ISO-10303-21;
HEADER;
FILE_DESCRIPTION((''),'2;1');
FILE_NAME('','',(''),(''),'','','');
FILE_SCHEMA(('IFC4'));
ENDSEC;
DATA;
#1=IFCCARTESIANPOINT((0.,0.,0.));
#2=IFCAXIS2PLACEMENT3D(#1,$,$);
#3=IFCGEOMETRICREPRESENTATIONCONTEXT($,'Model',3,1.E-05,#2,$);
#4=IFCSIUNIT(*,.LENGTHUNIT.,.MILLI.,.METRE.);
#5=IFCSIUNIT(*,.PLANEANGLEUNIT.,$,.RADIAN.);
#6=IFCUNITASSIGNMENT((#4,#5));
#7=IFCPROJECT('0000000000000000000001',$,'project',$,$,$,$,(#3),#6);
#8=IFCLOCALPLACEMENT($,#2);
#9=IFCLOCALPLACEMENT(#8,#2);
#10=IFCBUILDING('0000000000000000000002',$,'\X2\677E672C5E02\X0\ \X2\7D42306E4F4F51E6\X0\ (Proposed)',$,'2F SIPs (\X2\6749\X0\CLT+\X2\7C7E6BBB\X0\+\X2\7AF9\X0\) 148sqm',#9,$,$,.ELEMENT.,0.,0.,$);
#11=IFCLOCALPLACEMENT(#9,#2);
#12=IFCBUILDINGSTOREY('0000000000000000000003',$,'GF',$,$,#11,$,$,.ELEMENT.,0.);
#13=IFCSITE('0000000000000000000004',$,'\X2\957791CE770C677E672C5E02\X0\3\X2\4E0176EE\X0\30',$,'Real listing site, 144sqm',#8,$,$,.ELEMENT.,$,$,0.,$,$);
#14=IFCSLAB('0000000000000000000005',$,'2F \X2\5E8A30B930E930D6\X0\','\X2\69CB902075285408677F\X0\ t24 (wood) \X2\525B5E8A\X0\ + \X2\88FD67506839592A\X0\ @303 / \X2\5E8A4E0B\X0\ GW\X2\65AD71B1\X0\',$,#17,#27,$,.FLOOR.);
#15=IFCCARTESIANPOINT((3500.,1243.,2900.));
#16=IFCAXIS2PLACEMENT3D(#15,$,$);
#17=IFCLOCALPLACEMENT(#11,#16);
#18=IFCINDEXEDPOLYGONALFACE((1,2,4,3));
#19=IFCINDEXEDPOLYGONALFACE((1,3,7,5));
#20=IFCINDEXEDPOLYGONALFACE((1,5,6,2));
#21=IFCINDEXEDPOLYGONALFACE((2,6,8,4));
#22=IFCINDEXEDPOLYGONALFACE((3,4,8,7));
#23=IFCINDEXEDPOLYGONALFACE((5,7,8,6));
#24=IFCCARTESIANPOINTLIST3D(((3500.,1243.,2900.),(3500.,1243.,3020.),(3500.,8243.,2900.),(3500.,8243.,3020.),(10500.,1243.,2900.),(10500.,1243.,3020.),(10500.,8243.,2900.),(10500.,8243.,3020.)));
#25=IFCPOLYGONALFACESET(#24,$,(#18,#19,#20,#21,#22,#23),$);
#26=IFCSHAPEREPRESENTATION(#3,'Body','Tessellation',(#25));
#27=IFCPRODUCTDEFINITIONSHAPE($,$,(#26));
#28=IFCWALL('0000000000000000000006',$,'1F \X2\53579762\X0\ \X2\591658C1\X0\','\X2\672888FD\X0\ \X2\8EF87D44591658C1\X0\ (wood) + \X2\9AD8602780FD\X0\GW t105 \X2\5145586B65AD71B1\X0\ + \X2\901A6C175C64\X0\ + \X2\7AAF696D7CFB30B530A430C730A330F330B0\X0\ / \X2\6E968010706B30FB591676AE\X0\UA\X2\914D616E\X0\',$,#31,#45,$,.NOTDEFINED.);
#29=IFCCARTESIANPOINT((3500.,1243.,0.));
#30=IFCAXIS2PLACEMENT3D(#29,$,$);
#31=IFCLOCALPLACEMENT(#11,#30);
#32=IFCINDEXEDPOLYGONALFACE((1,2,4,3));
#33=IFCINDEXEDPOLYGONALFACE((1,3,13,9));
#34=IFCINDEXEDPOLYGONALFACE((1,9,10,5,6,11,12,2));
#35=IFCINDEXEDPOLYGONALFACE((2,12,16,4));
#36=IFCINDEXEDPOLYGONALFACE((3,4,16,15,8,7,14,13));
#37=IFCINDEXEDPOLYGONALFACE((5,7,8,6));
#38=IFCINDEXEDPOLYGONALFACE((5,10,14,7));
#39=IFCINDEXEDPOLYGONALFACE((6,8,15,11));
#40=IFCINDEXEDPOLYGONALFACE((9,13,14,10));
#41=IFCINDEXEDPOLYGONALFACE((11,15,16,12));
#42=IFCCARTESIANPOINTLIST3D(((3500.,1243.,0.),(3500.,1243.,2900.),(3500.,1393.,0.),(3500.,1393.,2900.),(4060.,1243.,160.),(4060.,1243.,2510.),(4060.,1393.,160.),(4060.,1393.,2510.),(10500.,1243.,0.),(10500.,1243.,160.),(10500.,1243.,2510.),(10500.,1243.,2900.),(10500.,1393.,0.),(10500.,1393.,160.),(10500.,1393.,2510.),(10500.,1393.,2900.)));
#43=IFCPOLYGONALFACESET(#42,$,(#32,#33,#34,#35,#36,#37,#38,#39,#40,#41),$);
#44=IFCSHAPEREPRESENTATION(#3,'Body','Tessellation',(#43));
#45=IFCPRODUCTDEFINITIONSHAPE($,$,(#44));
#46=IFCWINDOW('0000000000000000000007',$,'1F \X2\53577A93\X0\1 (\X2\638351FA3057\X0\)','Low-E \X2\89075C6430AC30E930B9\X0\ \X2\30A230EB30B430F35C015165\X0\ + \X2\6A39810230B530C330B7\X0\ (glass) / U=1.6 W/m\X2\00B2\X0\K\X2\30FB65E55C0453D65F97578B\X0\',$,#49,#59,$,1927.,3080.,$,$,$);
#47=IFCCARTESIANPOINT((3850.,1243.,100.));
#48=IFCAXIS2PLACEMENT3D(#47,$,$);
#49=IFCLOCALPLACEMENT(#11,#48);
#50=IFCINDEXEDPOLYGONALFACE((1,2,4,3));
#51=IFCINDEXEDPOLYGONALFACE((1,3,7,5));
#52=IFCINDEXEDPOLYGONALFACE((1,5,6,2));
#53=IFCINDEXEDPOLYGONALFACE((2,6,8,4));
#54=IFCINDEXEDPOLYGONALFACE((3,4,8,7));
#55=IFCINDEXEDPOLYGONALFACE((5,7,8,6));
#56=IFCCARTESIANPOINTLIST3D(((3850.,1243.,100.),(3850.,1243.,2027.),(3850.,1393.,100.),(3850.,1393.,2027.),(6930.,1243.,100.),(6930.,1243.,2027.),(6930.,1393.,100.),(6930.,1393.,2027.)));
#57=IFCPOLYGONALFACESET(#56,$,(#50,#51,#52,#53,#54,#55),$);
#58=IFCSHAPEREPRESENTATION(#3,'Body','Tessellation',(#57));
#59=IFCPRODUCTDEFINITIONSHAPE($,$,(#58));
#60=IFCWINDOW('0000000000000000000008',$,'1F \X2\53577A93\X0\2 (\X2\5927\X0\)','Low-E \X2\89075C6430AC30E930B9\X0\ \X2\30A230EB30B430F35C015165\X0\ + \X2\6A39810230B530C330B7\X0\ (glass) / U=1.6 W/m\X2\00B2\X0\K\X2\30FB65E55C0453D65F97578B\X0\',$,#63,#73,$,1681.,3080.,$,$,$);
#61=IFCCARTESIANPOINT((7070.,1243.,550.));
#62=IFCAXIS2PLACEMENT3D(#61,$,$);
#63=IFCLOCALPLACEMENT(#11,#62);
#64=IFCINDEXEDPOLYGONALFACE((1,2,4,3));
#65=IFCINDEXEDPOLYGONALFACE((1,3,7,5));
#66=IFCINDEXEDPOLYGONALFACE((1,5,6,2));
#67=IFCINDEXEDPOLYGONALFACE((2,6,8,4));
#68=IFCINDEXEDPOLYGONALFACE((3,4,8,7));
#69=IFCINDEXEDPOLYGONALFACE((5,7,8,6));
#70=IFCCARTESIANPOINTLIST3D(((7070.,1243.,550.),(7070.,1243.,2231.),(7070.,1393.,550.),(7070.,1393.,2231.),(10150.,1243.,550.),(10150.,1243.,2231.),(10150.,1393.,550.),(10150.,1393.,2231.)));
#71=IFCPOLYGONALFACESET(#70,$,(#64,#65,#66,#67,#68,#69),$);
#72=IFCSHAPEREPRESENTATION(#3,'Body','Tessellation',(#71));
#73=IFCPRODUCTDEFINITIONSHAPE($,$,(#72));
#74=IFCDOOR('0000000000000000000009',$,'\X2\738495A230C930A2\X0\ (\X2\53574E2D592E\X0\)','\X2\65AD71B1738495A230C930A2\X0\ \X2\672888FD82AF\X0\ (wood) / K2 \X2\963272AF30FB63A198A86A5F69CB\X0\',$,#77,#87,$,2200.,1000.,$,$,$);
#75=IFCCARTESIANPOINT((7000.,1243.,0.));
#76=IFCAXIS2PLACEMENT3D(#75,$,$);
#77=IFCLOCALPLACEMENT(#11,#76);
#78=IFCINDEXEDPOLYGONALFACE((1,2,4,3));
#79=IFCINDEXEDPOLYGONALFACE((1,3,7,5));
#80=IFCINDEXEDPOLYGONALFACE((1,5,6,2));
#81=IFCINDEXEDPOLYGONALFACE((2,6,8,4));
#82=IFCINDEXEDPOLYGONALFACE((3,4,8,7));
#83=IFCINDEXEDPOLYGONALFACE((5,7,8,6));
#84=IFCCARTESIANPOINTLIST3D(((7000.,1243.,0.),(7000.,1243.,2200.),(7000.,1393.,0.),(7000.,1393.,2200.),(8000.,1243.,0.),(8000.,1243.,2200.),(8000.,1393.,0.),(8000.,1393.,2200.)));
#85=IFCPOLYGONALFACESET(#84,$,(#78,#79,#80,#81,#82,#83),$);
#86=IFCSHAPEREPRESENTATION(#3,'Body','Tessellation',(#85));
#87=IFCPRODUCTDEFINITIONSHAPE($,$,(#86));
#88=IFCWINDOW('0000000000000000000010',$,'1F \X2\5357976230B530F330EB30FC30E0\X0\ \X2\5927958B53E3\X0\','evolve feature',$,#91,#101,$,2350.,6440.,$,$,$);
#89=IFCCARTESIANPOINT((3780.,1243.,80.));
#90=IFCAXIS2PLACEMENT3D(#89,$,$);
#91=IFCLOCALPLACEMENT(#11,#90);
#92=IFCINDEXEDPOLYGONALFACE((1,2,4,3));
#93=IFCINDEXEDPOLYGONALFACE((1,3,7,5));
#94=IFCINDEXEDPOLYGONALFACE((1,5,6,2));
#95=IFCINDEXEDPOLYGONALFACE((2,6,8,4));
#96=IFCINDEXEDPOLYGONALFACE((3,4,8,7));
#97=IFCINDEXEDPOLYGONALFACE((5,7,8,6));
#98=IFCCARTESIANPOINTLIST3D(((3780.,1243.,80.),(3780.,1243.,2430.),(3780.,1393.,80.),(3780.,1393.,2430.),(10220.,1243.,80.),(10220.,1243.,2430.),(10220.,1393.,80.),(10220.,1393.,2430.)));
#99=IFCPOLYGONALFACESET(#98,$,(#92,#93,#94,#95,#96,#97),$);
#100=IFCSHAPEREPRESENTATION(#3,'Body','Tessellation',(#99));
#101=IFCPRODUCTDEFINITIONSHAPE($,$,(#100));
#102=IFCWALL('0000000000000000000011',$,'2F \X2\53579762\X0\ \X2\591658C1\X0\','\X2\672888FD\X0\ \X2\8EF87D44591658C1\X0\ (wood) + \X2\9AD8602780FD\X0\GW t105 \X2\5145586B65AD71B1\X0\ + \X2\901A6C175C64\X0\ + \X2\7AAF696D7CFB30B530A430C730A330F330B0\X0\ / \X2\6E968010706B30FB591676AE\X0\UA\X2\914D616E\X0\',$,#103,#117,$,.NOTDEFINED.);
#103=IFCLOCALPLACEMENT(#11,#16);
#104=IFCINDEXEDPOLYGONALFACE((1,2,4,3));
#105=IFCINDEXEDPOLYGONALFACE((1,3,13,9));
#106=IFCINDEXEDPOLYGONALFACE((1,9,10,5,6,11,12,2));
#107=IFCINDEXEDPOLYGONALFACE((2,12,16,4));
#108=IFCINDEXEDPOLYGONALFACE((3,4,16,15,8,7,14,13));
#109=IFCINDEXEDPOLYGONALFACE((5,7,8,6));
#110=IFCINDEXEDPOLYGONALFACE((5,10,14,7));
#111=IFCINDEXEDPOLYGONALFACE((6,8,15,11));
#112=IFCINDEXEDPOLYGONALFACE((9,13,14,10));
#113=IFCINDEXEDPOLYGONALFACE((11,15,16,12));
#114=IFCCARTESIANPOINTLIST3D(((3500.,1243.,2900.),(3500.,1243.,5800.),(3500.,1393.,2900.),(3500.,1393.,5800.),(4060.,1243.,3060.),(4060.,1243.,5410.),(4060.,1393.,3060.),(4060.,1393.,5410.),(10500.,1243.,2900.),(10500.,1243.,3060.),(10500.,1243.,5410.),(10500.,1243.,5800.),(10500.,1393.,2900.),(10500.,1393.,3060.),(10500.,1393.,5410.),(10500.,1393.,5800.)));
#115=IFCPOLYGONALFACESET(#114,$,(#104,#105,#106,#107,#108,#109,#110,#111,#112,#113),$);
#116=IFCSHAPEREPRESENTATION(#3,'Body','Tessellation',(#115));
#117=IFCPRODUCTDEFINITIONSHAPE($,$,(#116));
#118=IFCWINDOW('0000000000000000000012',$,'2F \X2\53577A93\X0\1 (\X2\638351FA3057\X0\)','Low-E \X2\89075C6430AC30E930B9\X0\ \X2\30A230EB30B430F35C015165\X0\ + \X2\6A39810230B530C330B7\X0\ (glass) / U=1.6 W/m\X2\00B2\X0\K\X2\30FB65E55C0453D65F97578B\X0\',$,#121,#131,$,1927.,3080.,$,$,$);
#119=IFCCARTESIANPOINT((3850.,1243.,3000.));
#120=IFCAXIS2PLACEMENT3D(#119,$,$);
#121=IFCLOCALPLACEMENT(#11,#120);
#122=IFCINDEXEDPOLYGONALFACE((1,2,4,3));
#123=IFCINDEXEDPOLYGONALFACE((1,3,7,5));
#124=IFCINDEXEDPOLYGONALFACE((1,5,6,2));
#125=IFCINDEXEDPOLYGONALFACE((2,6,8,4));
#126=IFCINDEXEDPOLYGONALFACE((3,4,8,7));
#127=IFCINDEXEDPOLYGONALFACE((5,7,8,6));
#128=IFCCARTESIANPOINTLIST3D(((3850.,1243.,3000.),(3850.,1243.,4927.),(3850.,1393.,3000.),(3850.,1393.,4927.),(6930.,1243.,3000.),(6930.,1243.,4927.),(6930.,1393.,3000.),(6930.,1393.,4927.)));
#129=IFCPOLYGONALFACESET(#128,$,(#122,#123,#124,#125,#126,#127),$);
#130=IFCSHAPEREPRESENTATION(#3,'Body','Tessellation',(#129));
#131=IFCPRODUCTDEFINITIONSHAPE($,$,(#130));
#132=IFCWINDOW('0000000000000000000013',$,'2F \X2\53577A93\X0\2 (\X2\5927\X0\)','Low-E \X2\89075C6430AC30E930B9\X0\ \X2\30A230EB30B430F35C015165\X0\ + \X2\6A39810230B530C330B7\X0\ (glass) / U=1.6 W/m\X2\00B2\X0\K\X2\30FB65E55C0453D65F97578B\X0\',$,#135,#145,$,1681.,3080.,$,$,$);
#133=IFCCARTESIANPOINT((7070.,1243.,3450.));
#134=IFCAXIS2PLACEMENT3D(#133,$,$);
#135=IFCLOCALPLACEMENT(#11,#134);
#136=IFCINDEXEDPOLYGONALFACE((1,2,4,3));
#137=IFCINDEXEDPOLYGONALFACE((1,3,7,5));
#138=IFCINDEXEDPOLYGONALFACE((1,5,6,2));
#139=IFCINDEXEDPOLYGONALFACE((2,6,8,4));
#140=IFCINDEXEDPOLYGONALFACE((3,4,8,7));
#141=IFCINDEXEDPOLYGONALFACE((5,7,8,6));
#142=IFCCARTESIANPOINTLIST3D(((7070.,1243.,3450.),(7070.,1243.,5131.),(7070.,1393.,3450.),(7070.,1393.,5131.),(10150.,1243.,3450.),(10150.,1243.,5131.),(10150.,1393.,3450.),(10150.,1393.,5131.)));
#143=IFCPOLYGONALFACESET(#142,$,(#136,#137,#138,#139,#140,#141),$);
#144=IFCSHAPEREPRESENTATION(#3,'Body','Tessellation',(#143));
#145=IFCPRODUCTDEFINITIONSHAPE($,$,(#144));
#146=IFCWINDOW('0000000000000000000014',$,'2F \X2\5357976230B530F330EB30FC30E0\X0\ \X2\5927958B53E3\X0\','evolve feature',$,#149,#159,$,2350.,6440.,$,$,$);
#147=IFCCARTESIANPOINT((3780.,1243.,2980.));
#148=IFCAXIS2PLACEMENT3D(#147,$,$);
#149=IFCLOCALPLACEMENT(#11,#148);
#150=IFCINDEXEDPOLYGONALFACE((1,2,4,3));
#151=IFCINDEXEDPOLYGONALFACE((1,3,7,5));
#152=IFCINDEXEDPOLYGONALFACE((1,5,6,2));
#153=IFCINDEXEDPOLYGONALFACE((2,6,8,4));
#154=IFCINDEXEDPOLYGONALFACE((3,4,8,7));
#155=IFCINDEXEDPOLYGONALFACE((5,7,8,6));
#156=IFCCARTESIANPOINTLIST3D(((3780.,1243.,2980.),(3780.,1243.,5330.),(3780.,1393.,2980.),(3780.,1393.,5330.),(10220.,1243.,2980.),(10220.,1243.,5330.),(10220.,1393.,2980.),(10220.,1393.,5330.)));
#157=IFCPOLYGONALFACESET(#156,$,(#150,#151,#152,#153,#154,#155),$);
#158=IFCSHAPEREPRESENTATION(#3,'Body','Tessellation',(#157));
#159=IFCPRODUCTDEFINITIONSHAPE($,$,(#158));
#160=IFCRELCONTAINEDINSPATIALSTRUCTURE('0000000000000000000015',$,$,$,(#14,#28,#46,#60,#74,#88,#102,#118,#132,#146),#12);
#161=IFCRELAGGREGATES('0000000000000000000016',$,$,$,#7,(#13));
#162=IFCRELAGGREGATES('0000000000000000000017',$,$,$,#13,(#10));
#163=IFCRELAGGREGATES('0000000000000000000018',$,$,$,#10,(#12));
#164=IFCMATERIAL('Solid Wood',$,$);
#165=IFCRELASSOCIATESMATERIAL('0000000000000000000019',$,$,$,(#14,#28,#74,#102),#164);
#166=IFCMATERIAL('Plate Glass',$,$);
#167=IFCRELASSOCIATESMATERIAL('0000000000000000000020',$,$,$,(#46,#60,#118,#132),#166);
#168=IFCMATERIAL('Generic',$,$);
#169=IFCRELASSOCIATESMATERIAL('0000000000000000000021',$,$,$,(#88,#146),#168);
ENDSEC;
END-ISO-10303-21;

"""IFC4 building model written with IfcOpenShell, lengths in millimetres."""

from ifc_helpers import new_model, si_unit, frame, frame_2d, origin, place, context, project, spatial, rectangle, extrude, material, element, fill, save


model = new_model("IFC4")

# Units and contexts
model_context = context("Model", 3, precision=1e-05, world=origin())
ifc_project = project(units=[si_unit("LENGTHUNIT", "METRE", prefix="MILLI"), si_unit("PLANEANGLEUNIT", "RADIAN")], contexts=[model_context])

# Site, building, storey
site_placement = place(None, origin())
site = spatial("IfcSite", under=ifc_project, at=site_placement, Name="長野県松本市3丁目30", ObjectType="Real listing site, 144sqm", CompositionType="ELEMENT", RefElevation=0.0)
building_placement = place(site_placement, origin())
building = spatial("IfcBuilding", under=site, at=building_placement, Name="松本市 終の住処 (Proposed)", ObjectType="2F SIPs (杉CLT+籾殻+竹) 148sqm", CompositionType="ELEMENT", ElevationOfRefHeight=0.0, ElevationOfTerrain=0.0)
storey_placement = place(building_placement, origin())
storey = spatial("IfcBuildingStorey", under=building, at=storey_placement, Name="GF", CompositionType="ELEMENT", Elevation=0.0)

# Slab
ifc_material_1 = material(Name="Solid Wood")
slab_1_placement = place(storey_placement, frame((3500.0, 1243.0, 2900.0)))
element("IfcSlab", 1, at=slab_1_placement, inside=storey, material=ifc_material_1, Name="2F 床スラブ", Description="構造用合板 t24 (wood) 剛床 + 製材根太 @303 / 床下 GW断熱", PredefinedType="FLOOR", context=model_context, shape_type="SweptSolid", body=[
    extrude(rectangle(XDim=7000.0, YDim=7000.0, at=frame_2d((3500.0, 3500.0))), frame((3500.0, 1243.0, 2900.0)), (0.0, 0.0, 1.0), 120.0),
])
ifc_material_2 = material(Name="Generic")

# Wall, openings, windows, door
wall_1_placement = place(storey_placement, frame((3500.0, 1243.0, 0.0)))
wall_1 = element("IfcWall", 2, at=wall_1_placement, inside=storey, material=ifc_material_1, Name="1F 南面 外壁", Description="木製 軸組外壁 (wood) + 高性能GW t105 充填断熱 + 通気層 + 窯業系サイディング / 準耐火・外皮UA配慮", PredefinedType="NOTDEFINED", context=model_context, shape_type="SweptSolid", body=[
    extrude(rectangle(XDim=7000.0, YDim=150.0, at=frame_2d((3500.0, 75.0))), frame((3500.0, 1243.0, 0.0)), (0.0, 0.0, 1.0), 2900.0),
])
opening_1_placement = place(storey_placement, frame((3850.0, 1243.0, 100.0)))
opening_1 = element("IfcOpeningElement", 3, at=opening_1_placement, cuts=wall_1, PredefinedType="NOTDEFINED", context=model_context, shape_type="SweptSolid", body=[
    extrude(rectangle(XDim=3080.0, YDim=150.0, at=frame_2d((1540.0, 75.0))), frame((3850.0, 1243.0, 100.0)), (0.0, 0.0, 1.0), 1927.0),
])
opening_2_placement = place(storey_placement, frame((7070.0, 1243.0, 550.0)))
opening_2 = element("IfcOpeningElement", 4, at=opening_2_placement, cuts=wall_1, PredefinedType="NOTDEFINED", context=model_context, shape_type="SweptSolid", body=[
    extrude(rectangle(XDim=3080.0, YDim=150.0, at=frame_2d((1540.0, 75.0))), frame((7070.0, 1243.0, 550.0)), (0.0, 0.0, 1.0), 1681.0),
])
opening_3_placement = place(storey_placement, frame((7000.0, 1243.0, 0.0)))
opening_3 = element("IfcOpeningElement", 5, at=opening_3_placement, cuts=wall_1, PredefinedType="NOTDEFINED", context=model_context, shape_type="SweptSolid", body=[
    extrude(rectangle(XDim=1000.0, YDim=150.0, at=frame_2d((500.0, 75.0))), frame((7000.0, 1243.0, 0.0)), (0.0, 0.0, 1.0), 2200.0),
])
opening_4_placement = place(storey_placement, frame((3780.0, 1243.0, 80.0)))
opening_4 = element("IfcOpeningElement", 6, at=opening_4_placement, cuts=wall_1, PredefinedType="NOTDEFINED", context=model_context, shape_type="SweptSolid", body=[
    extrude(rectangle(XDim=6440.0, YDim=150.0, at=frame_2d((3220.0, 75.0))), frame((3780.0, 1243.0, 80.0)), (0.0, 0.0, 1.0), 2350.0),
])
ifc_material_3 = material(Name="Plate Glass")
window_1_placement = place(storey_placement, frame((3850.0, 1243.0, 100.0)))
window_1 = element("IfcWindow", 7, at=window_1_placement, inside=storey, material=ifc_material_3, Name="1F 南窓1 (掃出し)", Description="Low-E 複層ガラス アルゴン封入 + 樹脂サッシ (glass) / U=1.6 W/m²K・日射取得型", OverallHeight=1927.0, OverallWidth=3080.0, context=model_context, shape_type="SweptSolid", body=[
    extrude(rectangle(XDim=3080.0, YDim=150.0, at=frame_2d((1540.0, 75.0))), frame((3850.0, 1243.0, 100.0)), (0.0, 0.0, 1.0), 1927.0),
])
fill(opening_1, window_1)
window_2_placement = place(storey_placement, frame((7070.0, 1243.0, 550.0)))
window_2 = element("IfcWindow", 8, at=window_2_placement, inside=storey, material=ifc_material_3, Name="1F 南窓2 (大)", Description="Low-E 複層ガラス アルゴン封入 + 樹脂サッシ (glass) / U=1.6 W/m²K・日射取得型", OverallHeight=1681.0, OverallWidth=3080.0, context=model_context, shape_type="SweptSolid", body=[
    extrude(rectangle(XDim=3080.0, YDim=150.0, at=frame_2d((1540.0, 75.0))), frame((7070.0, 1243.0, 550.0)), (0.0, 0.0, 1.0), 1681.0),
])
fill(opening_2, window_2)
door_placement = place(storey_placement, frame((7000.0, 1243.0, 0.0)))
door = element("IfcDoor", 9, at=door_placement, inside=storey, material=ifc_material_1, Name="玄関ドア (南中央)", Description="断熱玄関ドア 木製芯 (wood) / K2 防犯・採風機構", OverallHeight=2200.0, OverallWidth=1000.0, context=model_context, shape_type="SweptSolid", body=[
    extrude(rectangle(XDim=1000.0, YDim=150.0, at=frame_2d((500.0, 75.0))), frame((7000.0, 1243.0, 0.0)), (0.0, 0.0, 1.0), 2200.0),
])
fill(opening_3, door)
window_3_placement = place(storey_placement, frame((3780.0, 1243.0, 80.0)))
window_3 = element("IfcWindow", 10, at=window_3_placement, inside=storey, material=ifc_material_2, Name="1F 南面サンルーム 大開口", Description="evolve feature", OverallHeight=2350.0, OverallWidth=6440.0, context=model_context, shape_type="SweptSolid", body=[
    extrude(rectangle(XDim=6440.0, YDim=150.0, at=frame_2d((3220.0, 75.0))), frame((3780.0, 1243.0, 80.0)), (0.0, 0.0, 1.0), 2350.0),
])
fill(opening_4, window_3)

# Wall, openings, windows
wall_2_placement = place(storey_placement, frame((3500.0, 1243.0, 2900.0)))
wall_2 = element("IfcWall", 11, at=wall_2_placement, inside=storey, material=ifc_material_1, Name="2F 南面 外壁", Description="木製 軸組外壁 (wood) + 高性能GW t105 充填断熱 + 通気層 + 窯業系サイディング / 準耐火・外皮UA配慮", PredefinedType="NOTDEFINED", context=model_context, shape_type="SweptSolid", body=[
    extrude(rectangle(XDim=7000.0, YDim=150.0, at=frame_2d((3500.0, 75.0))), frame((3500.0, 1243.0, 2900.0)), (0.0, 0.0, 1.0), 2900.0),
])
opening_5_placement = place(storey_placement, frame((3850.0, 1243.0, 3000.0)))
opening_5 = element("IfcOpeningElement", 12, at=opening_5_placement, cuts=wall_2, PredefinedType="NOTDEFINED", context=model_context, shape_type="SweptSolid", body=[
    extrude(rectangle(XDim=3080.0, YDim=150.0, at=frame_2d((1540.0, 75.0))), frame((3850.0, 1243.0, 3000.0)), (0.0, 0.0, 1.0), 1927.0),
])
opening_6_placement = place(storey_placement, frame((7070.0, 1243.0, 3450.0)))
opening_6 = element("IfcOpeningElement", 13, at=opening_6_placement, cuts=wall_2, PredefinedType="NOTDEFINED", context=model_context, shape_type="SweptSolid", body=[
    extrude(rectangle(XDim=3080.0, YDim=150.0, at=frame_2d((1540.0, 75.0))), frame((7070.0, 1243.0, 3450.0)), (0.0, 0.0, 1.0), 1681.0),
])
opening_7_placement = place(storey_placement, frame((3780.0, 1243.0, 2980.0)))
opening_7 = element("IfcOpeningElement", 14, at=opening_7_placement, cuts=wall_2, PredefinedType="NOTDEFINED", context=model_context, shape_type="SweptSolid", body=[
    extrude(rectangle(XDim=6440.0, YDim=150.0, at=frame_2d((3220.0, 75.0))), frame((3780.0, 1243.0, 2980.0)), (0.0, 0.0, 1.0), 2350.0),
])
window_4_placement = place(storey_placement, frame((3850.0, 1243.0, 3000.0)))
window_4 = element("IfcWindow", 15, at=window_4_placement, inside=storey, material=ifc_material_3, Name="2F 南窓1 (掃出し)", Description="Low-E 複層ガラス アルゴン封入 + 樹脂サッシ (glass) / U=1.6 W/m²K・日射取得型", OverallHeight=1927.0, OverallWidth=3080.0, context=model_context, shape_type="SweptSolid", body=[
    extrude(rectangle(XDim=3080.0, YDim=150.0, at=frame_2d((1540.0, 75.0))), frame((3850.0, 1243.0, 3000.0)), (0.0, 0.0, 1.0), 1927.0),
])
fill(opening_5, window_4)
window_5_placement = place(storey_placement, frame((7070.0, 1243.0, 3450.0)))
window_5 = element("IfcWindow", 16, at=window_5_placement, inside=storey, material=ifc_material_3, Name="2F 南窓2 (大)", Description="Low-E 複層ガラス アルゴン封入 + 樹脂サッシ (glass) / U=1.6 W/m²K・日射取得型", OverallHeight=1681.0, OverallWidth=3080.0, context=model_context, shape_type="SweptSolid", body=[
    extrude(rectangle(XDim=3080.0, YDim=150.0, at=frame_2d((1540.0, 75.0))), frame((7070.0, 1243.0, 3450.0)), (0.0, 0.0, 1.0), 1681.0),
])
fill(opening_6, window_5)
window_6_placement = place(storey_placement, frame((3780.0, 1243.0, 2980.0)))
window_6 = element("IfcWindow", 17, at=window_6_placement, inside=storey, material=ifc_material_2, Name="2F 南面サンルーム 大開口", Description="evolve feature", OverallHeight=2350.0, OverallWidth=6440.0, context=model_context, shape_type="SweptSolid", body=[
    extrude(rectangle(XDim=6440.0, YDim=150.0, at=frame_2d((3220.0, 75.0))), frame((3780.0, 1243.0, 2980.0)), (0.0, 0.0, 1.0), 2350.0),
])
fill(opening_7, window_6)

save(model, "model.ifc")
